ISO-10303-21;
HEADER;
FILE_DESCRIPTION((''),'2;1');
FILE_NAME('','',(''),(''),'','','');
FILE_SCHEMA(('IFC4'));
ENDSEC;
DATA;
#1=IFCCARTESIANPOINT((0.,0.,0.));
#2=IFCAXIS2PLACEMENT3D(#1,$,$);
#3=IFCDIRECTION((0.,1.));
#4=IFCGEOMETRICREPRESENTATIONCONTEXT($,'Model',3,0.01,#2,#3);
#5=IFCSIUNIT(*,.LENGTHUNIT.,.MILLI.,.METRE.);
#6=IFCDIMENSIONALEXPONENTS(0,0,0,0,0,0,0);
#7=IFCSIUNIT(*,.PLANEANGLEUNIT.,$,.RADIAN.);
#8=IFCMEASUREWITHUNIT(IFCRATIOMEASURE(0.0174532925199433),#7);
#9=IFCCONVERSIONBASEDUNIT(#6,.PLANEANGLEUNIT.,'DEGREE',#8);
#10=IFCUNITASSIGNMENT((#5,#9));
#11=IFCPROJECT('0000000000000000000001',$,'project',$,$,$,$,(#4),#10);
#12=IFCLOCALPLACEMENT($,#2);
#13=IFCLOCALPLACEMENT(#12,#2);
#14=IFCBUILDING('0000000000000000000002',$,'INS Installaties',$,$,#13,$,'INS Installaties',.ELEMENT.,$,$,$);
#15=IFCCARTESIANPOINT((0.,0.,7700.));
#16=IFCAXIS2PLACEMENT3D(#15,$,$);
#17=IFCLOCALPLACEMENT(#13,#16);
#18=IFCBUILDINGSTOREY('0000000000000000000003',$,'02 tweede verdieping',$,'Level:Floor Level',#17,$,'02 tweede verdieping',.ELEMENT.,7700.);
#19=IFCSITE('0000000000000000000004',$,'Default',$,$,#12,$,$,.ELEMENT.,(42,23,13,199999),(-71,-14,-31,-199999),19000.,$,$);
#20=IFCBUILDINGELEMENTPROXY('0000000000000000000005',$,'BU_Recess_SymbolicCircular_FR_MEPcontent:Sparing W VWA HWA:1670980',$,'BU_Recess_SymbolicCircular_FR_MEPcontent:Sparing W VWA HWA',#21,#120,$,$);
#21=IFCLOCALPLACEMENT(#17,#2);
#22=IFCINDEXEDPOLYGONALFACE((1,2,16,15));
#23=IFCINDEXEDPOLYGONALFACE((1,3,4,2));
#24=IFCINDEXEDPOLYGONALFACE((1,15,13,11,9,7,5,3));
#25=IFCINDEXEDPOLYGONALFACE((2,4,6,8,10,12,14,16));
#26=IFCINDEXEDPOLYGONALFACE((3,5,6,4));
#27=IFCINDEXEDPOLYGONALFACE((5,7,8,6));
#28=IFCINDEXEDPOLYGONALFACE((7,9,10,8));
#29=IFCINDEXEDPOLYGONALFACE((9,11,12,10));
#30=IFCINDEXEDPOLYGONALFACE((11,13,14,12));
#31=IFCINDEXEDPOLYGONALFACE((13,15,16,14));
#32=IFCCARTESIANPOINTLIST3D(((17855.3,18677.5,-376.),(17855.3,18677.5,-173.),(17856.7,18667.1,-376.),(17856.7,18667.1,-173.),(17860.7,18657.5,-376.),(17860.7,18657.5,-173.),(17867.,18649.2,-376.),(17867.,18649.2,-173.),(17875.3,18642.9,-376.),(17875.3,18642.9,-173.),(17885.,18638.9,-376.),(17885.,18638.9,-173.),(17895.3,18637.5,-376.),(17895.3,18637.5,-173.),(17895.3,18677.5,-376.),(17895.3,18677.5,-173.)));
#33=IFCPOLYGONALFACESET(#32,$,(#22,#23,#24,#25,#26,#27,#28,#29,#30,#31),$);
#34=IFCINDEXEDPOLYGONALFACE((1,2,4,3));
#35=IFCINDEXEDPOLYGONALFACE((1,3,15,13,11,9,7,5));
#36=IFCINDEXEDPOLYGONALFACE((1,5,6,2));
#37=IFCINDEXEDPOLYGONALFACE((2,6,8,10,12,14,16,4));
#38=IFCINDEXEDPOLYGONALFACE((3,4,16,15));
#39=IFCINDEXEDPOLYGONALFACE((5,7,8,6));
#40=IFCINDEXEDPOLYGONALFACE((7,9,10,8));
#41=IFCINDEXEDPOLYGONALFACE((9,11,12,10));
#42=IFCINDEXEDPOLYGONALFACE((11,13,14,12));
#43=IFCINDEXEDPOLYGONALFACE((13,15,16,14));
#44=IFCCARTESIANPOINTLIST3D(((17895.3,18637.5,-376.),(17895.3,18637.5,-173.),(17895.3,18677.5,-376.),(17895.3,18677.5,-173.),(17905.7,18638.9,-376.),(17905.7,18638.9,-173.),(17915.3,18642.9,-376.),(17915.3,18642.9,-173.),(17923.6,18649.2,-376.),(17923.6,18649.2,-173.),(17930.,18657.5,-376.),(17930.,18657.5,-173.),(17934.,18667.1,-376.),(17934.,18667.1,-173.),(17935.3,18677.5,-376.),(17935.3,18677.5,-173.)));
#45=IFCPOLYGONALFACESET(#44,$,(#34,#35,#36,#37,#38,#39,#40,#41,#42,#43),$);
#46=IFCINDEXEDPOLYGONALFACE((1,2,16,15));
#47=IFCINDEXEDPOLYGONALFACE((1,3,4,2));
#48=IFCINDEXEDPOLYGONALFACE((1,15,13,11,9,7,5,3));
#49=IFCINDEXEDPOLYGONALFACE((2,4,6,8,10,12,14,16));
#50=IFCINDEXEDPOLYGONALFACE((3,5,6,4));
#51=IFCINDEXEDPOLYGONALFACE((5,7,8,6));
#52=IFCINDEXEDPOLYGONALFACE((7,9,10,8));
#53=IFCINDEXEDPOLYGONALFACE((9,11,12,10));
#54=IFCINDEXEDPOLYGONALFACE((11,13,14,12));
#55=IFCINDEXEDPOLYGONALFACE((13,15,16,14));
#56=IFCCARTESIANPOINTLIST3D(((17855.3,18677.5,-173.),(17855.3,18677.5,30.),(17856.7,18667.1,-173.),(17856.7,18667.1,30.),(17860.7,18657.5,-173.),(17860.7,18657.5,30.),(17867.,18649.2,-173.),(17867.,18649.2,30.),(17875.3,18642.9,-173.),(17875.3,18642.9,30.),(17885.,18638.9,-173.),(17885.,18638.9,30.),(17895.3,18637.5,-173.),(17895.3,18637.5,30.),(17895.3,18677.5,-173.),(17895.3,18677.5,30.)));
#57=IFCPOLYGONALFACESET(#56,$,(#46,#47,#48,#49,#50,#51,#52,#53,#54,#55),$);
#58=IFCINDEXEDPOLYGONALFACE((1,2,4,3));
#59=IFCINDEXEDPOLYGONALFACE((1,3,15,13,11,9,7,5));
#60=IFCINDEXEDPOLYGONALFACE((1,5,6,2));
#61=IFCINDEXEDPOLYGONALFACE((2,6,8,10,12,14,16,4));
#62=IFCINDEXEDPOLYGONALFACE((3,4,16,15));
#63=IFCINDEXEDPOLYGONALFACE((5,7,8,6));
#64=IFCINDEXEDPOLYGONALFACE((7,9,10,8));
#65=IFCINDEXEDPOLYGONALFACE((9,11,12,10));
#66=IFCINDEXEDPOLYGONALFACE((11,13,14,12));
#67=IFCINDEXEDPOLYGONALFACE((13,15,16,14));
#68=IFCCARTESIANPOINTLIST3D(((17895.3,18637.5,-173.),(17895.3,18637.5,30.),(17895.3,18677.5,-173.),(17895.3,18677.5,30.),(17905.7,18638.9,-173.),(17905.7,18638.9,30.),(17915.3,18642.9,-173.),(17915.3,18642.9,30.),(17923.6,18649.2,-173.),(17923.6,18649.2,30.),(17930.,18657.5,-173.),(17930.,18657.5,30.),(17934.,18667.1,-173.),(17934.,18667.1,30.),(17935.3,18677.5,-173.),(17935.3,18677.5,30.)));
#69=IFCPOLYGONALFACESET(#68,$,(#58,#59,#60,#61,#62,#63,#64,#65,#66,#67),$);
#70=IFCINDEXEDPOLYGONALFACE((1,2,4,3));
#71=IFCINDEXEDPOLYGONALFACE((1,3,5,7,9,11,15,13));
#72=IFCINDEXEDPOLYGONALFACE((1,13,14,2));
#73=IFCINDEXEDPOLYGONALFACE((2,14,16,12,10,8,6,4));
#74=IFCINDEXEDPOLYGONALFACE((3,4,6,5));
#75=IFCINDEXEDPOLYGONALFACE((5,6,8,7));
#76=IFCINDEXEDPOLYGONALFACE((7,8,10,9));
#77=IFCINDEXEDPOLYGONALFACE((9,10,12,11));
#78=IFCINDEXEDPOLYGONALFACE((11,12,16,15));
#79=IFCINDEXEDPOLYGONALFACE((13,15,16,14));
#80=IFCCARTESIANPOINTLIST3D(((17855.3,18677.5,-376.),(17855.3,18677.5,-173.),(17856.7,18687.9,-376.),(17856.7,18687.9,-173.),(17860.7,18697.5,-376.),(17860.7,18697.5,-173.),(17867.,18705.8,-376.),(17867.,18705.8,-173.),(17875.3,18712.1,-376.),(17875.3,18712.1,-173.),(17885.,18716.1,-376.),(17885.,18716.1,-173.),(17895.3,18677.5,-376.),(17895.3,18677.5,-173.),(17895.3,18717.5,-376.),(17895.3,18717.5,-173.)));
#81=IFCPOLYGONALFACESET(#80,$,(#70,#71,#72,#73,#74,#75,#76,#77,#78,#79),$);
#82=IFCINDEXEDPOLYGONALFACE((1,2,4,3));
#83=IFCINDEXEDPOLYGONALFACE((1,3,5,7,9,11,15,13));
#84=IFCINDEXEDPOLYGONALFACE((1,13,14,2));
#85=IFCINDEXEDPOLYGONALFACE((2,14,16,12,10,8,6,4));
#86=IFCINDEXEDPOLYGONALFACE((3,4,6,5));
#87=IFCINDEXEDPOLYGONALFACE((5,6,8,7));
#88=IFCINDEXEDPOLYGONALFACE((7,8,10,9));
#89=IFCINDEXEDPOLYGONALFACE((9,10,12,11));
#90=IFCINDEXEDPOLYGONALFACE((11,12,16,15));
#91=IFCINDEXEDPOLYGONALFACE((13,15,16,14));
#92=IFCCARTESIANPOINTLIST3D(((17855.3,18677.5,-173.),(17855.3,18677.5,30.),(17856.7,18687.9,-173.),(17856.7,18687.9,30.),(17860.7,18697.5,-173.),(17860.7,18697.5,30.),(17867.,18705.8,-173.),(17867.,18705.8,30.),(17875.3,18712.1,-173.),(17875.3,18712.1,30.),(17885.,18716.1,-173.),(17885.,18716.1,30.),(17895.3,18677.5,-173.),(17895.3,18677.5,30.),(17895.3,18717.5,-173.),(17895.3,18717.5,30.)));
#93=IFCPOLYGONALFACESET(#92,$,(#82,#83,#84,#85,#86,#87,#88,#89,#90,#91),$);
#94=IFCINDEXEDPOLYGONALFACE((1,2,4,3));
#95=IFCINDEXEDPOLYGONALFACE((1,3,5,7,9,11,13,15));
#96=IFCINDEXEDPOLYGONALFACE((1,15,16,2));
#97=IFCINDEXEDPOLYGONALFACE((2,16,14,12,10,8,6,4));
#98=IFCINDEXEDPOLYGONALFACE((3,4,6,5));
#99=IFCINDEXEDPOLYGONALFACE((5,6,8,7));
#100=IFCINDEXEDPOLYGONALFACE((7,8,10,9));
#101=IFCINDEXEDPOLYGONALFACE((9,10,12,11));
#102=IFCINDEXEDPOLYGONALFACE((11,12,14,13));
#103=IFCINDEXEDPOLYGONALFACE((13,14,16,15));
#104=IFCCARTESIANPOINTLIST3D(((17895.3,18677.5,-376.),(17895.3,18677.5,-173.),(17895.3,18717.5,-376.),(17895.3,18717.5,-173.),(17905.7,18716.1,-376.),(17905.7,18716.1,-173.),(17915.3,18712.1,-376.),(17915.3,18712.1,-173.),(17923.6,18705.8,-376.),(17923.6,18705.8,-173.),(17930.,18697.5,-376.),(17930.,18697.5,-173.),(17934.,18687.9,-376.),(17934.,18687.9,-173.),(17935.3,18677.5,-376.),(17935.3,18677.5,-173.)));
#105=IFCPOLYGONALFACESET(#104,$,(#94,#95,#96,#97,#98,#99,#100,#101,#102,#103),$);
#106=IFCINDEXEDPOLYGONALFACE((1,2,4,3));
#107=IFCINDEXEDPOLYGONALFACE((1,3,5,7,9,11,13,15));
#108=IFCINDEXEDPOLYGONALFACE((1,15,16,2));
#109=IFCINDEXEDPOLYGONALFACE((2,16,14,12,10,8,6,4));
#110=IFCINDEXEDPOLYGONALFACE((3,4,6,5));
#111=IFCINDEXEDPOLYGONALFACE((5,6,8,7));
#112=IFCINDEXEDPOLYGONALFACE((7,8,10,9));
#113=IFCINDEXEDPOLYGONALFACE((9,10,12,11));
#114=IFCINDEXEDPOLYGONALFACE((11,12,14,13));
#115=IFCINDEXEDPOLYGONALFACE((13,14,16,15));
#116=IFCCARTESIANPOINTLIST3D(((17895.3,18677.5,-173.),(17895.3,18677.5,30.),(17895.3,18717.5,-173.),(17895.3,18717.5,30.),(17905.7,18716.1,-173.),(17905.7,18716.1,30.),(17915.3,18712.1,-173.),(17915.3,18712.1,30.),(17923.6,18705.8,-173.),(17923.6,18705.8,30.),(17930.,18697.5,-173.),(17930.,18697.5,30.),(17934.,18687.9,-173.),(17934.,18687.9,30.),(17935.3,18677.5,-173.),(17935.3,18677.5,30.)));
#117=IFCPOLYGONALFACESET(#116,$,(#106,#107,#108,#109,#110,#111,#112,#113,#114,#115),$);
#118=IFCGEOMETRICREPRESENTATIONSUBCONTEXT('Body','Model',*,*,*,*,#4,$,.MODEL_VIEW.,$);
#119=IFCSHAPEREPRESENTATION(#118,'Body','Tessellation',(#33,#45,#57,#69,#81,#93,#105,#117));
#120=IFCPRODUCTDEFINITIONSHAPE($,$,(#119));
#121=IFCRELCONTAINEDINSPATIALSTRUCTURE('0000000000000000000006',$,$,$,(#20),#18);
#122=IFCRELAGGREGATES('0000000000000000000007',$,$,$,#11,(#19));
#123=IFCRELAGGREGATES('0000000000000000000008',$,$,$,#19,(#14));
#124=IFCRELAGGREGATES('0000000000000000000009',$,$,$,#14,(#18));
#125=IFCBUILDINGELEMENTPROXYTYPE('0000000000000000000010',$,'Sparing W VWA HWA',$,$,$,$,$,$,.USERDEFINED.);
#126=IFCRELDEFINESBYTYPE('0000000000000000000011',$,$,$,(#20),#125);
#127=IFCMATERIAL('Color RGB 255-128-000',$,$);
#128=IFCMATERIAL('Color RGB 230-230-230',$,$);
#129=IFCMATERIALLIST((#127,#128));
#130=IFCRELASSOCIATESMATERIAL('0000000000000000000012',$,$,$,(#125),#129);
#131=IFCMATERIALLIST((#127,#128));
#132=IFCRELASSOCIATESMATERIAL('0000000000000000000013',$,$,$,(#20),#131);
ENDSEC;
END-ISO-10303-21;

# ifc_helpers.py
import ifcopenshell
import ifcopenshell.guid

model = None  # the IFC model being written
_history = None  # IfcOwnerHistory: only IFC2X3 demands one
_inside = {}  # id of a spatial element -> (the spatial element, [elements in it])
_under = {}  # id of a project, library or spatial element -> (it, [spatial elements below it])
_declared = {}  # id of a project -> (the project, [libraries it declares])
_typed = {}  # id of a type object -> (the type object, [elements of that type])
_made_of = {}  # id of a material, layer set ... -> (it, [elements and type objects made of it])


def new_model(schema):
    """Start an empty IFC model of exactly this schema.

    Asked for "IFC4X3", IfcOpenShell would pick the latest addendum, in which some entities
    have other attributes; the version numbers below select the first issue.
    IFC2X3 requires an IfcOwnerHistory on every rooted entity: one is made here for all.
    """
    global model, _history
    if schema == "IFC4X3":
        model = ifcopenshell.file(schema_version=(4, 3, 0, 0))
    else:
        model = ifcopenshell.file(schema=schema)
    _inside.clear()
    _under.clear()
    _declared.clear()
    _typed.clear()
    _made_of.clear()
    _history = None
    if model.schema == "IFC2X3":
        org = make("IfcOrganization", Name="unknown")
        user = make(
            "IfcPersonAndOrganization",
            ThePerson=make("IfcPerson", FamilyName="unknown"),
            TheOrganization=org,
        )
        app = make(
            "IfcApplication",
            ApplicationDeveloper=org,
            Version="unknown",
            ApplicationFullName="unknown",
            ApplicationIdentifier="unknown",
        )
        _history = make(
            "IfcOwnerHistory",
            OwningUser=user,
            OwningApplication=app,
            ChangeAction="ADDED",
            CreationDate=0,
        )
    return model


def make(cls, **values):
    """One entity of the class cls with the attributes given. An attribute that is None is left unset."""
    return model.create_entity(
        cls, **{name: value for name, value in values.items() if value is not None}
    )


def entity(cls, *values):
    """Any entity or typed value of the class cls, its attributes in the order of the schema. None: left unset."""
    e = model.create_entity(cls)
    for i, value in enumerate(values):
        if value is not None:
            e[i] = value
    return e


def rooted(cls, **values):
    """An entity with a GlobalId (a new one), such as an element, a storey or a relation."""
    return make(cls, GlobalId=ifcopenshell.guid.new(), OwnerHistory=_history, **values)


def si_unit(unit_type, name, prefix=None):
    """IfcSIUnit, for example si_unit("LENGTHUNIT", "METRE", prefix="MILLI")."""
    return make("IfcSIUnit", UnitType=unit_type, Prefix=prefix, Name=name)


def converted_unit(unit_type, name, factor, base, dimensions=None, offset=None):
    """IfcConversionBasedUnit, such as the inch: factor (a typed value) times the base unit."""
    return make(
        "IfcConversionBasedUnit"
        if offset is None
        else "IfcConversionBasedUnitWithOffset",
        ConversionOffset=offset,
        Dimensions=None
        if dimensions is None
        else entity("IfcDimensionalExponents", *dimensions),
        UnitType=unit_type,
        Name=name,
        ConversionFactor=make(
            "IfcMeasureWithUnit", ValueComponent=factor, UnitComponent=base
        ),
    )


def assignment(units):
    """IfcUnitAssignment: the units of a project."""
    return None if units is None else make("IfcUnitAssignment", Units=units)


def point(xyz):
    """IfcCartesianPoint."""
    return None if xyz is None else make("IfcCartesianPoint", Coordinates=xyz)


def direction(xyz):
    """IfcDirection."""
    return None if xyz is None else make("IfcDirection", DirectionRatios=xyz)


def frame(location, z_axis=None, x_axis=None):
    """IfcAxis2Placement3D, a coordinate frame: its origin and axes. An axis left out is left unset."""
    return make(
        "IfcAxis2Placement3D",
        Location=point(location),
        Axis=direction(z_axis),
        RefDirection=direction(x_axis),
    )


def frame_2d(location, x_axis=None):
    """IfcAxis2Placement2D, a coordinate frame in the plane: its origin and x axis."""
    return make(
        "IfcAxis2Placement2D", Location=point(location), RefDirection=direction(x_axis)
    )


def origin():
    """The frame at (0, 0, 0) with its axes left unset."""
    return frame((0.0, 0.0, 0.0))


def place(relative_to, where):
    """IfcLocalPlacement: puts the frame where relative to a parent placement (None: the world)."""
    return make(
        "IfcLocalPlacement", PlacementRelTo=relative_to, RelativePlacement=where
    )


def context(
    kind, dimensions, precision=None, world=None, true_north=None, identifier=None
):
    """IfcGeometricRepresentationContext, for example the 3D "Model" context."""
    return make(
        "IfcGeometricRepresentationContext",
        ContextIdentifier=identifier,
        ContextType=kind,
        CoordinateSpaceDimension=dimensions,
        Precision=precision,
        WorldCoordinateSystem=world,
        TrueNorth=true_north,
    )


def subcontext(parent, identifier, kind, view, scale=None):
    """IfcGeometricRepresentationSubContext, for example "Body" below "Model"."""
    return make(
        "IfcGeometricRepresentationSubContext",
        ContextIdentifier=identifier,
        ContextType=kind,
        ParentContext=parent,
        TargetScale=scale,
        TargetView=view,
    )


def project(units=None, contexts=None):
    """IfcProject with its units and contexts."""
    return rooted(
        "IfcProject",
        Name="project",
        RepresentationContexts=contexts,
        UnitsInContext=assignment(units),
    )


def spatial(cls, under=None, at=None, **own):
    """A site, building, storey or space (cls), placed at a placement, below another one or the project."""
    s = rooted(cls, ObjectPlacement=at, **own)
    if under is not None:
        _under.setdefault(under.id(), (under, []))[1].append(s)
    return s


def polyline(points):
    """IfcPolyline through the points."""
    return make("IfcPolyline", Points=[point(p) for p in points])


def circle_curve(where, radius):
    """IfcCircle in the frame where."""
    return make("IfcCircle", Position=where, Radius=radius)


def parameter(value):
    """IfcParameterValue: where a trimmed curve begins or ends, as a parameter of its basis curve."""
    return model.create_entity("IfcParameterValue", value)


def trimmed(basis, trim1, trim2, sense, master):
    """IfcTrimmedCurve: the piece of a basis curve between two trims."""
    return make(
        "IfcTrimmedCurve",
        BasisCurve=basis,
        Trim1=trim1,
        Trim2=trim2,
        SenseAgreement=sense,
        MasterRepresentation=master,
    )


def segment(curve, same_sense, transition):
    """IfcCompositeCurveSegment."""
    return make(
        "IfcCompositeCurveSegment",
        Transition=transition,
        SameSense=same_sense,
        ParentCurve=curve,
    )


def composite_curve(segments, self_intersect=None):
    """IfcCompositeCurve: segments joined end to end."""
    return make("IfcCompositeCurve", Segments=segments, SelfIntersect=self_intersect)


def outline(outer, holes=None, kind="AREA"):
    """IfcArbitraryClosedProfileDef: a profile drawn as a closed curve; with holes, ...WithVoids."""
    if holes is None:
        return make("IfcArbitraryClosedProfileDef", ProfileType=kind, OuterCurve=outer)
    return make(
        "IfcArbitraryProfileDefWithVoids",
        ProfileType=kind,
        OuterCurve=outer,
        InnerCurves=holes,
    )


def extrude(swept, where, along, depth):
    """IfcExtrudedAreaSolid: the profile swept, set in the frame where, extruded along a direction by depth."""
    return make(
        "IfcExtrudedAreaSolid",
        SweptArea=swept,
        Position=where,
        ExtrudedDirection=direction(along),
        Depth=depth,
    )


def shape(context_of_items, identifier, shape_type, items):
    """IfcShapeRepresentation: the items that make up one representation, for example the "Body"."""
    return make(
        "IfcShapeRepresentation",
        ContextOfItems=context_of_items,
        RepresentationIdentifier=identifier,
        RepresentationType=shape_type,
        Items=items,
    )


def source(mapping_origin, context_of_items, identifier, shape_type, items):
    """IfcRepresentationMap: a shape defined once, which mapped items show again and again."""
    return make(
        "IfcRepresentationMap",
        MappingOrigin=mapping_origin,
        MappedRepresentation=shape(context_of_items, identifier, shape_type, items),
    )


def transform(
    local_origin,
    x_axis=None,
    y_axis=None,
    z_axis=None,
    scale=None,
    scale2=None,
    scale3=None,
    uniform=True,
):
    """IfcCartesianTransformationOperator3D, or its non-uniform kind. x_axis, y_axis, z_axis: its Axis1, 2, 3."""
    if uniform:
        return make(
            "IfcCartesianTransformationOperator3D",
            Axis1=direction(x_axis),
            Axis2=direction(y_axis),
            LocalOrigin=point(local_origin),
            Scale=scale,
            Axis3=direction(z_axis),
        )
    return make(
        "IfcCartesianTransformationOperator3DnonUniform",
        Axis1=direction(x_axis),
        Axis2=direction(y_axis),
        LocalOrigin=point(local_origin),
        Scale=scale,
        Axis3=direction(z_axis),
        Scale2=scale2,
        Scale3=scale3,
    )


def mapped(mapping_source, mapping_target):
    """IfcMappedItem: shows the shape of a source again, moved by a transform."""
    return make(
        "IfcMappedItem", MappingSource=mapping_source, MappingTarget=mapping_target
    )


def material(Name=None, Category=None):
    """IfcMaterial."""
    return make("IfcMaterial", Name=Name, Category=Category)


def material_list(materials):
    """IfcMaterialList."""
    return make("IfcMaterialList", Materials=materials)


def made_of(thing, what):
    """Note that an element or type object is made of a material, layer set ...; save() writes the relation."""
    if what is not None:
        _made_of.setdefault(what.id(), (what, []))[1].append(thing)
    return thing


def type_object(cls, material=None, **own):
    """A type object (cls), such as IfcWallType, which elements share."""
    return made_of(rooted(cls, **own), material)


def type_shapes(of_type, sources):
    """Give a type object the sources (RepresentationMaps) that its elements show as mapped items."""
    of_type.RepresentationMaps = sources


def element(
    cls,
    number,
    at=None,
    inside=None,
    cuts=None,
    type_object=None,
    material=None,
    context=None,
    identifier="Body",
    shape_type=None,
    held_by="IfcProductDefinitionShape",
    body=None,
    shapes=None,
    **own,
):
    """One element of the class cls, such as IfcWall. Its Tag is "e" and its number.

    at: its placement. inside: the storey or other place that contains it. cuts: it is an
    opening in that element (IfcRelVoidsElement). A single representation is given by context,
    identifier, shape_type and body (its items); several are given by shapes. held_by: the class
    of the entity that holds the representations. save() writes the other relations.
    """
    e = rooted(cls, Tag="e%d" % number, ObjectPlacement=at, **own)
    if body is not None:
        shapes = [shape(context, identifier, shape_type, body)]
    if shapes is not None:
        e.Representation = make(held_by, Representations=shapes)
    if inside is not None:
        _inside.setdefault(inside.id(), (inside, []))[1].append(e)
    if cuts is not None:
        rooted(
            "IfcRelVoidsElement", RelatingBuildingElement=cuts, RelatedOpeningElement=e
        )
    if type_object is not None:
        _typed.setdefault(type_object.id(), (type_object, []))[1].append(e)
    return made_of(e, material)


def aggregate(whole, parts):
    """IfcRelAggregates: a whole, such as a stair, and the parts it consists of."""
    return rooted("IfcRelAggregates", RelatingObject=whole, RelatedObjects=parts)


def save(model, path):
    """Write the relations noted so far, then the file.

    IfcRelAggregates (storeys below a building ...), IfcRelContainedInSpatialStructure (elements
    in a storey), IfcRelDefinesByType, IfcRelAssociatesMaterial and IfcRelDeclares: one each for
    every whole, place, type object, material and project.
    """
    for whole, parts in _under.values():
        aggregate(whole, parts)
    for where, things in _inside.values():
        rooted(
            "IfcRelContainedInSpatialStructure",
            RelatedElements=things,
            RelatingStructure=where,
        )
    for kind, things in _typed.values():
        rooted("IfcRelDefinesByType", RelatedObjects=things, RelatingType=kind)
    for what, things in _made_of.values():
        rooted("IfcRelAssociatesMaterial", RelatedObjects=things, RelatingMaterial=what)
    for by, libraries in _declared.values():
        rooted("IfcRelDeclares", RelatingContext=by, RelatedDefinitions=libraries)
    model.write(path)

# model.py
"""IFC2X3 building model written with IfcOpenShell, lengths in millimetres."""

from ifc_helpers import new_model, entity, si_unit, converted_unit, direction, frame, frame_2d, origin, place, context, subcontext, project, spatial, polyline, circle_curve, parameter, trimmed, segment, composite_curve, outline, extrude, source, transform, mapped, material, material_list, type_object, type_shapes, element, save


model = new_model("IFC2X3")

# Units and contexts
model_context = context("Model", 3, precision=0.01, world=origin(), true_north=direction((0.0, 1.0)))
body_context = subcontext(model_context, "Body", "Model", "MODEL_VIEW")
ifc_project = project(units=[si_unit("LENGTHUNIT", "METRE", prefix="MILLI"), converted_unit("PLANEANGLEUNIT", "DEGREE", entity("IfcRatioMeasure", 0.0174532925199433), si_unit("PLANEANGLEUNIT", "RADIAN"), dimensions=[0, 0, 0, 0, 0, 0, 0])], contexts=[model_context])

# Site, building, storey
site_placement = place(None, origin())
site = spatial("IfcSite", under=ifc_project, at=site_placement, Name="Default", CompositionType="ELEMENT", RefLatitude=(42, 23, 13, 199999), RefLongitude=(-71, -14, -31, -199999), RefElevation=19000.0)
building_placement = place(site_placement, origin())
building = spatial("IfcBuilding", under=site, at=building_placement, Name="INS Installaties", LongName="INS Installaties", CompositionType="ELEMENT")
storey_placement = place(building_placement, frame((0.0, 0.0, 7700.0)))
storey = spatial("IfcBuildingStorey", under=building, at=storey_placement, Name="02 tweede verdieping", ObjectType="Level:Floor Level", LongName="02 tweede verdieping", CompositionType="ELEMENT", Elevation=7700.0)

# Building element proxy
ifc_material_1 = material(Name="Color RGB 255-128-000")
ifc_material_2 = material(Name="Color RGB 230-230-230")
ifc_material_list_1 = material_list([ifc_material_1, ifc_material_2])
building_element_proxy_type_1 = type_object("IfcBuildingElementProxyType", Name="Sparing W VWA HWA", PredefinedType="USERDEFINED", material=ifc_material_list_1)
shared_shape_1 = source(origin(), body_context, "Body", "SweptSolid", [
    extrude(outline(composite_curve([segment(trimmed(circle_curve(frame_2d((13.3, 13.3), x_axis=(1.0, 0.0)), 40.0), [parameter(180.0)], [parameter(270.0)], True, "PARAMETER"), True, "CONTINUOUS"), segment(polyline([(13.3, -26.7), (13.3, 13.3)]), True, "CONTINUOUS"), segment(polyline([(13.3, 13.3), (-26.7, 13.3)]), True, "CONTINUOUS")], self_intersect=False)), frame((13.3, 13.3, -403.0), z_axis=(0.0, 0.0, 1.0), x_axis=(-1.0, 0.0, 0.0)), (0.0, 0.0, 1.0), 203.0),
    extrude(outline(composite_curve([segment(polyline([(-26.7, -13.3), (13.3, -13.3)]), True, "CONTINUOUS"), segment(polyline([(13.3, -13.3), (13.3, 26.7)]), True, "CONTINUOUS"), segment(trimmed(circle_curve(frame_2d((13.3, -13.3), x_axis=(1.0, 0.0)), 40.0), [parameter(90.0)], [parameter(180.0)], True, "PARAMETER"), True, "CONTINUOUS")], self_intersect=False)), frame((-13.3, 13.3, -403.0)), (0.0, 0.0, 1.0), 203.0),
    extrude(outline(composite_curve([segment(trimmed(circle_curve(frame_2d((13.3, 13.3), x_axis=(1.0, 0.0)), 40.0), [parameter(180.0)], [parameter(270.0)], True, "PARAMETER"), True, "CONTINUOUS"), segment(polyline([(13.3, -26.7), (13.3, 13.3)]), True, "CONTINUOUS"), segment(polyline([(13.3, 13.3), (-26.7, 13.3)]), True, "CONTINUOUS")], self_intersect=False)), frame((13.3, 13.3, -200.0), z_axis=(0.0, 0.0, 1.0), x_axis=(-1.0, 0.0, 0.0)), (0.0, 0.0, 1.0), 203.0),
    extrude(outline(composite_curve([segment(polyline([(-26.7, -13.3), (13.3, -13.3)]), True, "CONTINUOUS"), segment(polyline([(13.3, -13.3), (13.3, 26.7)]), True, "CONTINUOUS"), segment(trimmed(circle_curve(frame_2d((13.3, -13.3), x_axis=(1.0, 0.0)), 40.0), [parameter(90.0)], [parameter(180.0)], True, "PARAMETER"), True, "CONTINUOUS")], self_intersect=False)), frame((-13.3, 13.3, -200.0)), (0.0, 0.0, 1.0), 203.0),
    extrude(outline(composite_curve([segment(polyline([(-26.7, -13.3), (13.3, -13.3)]), True, "CONTINUOUS"), segment(polyline([(13.3, -13.3), (13.3, 26.7)]), True, "CONTINUOUS"), segment(trimmed(circle_curve(frame_2d((13.3, -13.3), x_axis=(1.0, 0.0)), 40.0), [parameter(90.0)], [parameter(180.0)], True, "PARAMETER"), True, "CONTINUOUS")], self_intersect=False)), frame((13.3, -13.3, -403.0), z_axis=(0.0, 0.0, 1.0), x_axis=(-1.0, 0.0, 0.0)), (0.0, 0.0, 1.0), 203.0),
    extrude(outline(composite_curve([segment(polyline([(-26.7, -13.3), (13.3, -13.3)]), True, "CONTINUOUS"), segment(polyline([(13.3, -13.3), (13.3, 26.7)]), True, "CONTINUOUS"), segment(trimmed(circle_curve(frame_2d((13.3, -13.3), x_axis=(1.0, 0.0)), 40.0), [parameter(90.0)], [parameter(180.0)], True, "PARAMETER"), True, "CONTINUOUS")], self_intersect=False)), frame((13.3, -13.3, -200.0), z_axis=(0.0, 0.0, 1.0), x_axis=(-1.0, 0.0, 0.0)), (0.0, 0.0, 1.0), 203.0),
    extrude(outline(composite_curve([segment(trimmed(circle_curve(frame_2d((13.3, 13.3), x_axis=(1.0, 0.0)), 40.0), [parameter(180.0)], [parameter(270.0)], True, "PARAMETER"), True, "CONTINUOUS"), segment(polyline([(13.3, -26.7), (13.3, 13.3)]), True, "CONTINUOUS"), segment(polyline([(13.3, 13.3), (-26.7, 13.3)]), True, "CONTINUOUS")], self_intersect=False)), frame((-13.3, -13.3, -403.0)), (0.0, 0.0, 1.0), 203.0),
    extrude(outline(composite_curve([segment(trimmed(circle_curve(frame_2d((13.3, 13.3), x_axis=(1.0, 0.0)), 40.0), [parameter(180.0)], [parameter(270.0)], True, "PARAMETER"), True, "CONTINUOUS"), segment(polyline([(13.3, -26.7), (13.3, 13.3)]), True, "CONTINUOUS"), segment(polyline([(13.3, 13.3), (-26.7, 13.3)]), True, "CONTINUOUS")], self_intersect=False)), frame((-13.3, -13.3, -200.0)), (0.0, 0.0, 1.0), 203.0),
])
type_shapes(building_element_proxy_type_1, [shared_shape_1])
ifc_material_list_2 = material_list([ifc_material_1, ifc_material_2])
proxy_1_placement = place(storey_placement, frame((17895.3, 18677.5, 27.0), z_axis=(0.0, 0.0, 1.0), x_axis=(-1.0, 0.0, 0.0)))
element("IfcBuildingElementProxy", 1, at=proxy_1_placement, inside=storey, type_object=building_element_proxy_type_1, material=ifc_material_list_2, Name="BU_Recess_SymbolicCircular_FR_MEPcontent:Sparing W VWA HWA:1670980", ObjectType="BU_Recess_SymbolicCircular_FR_MEPcontent:Sparing W VWA HWA", context=body_context, shape_type="MappedRepresentation", body=[
    mapped(shared_shape_1, transform((0.0, 0.0, 0.0), scale=1.0)),
])

save(model, "model.ifc")
